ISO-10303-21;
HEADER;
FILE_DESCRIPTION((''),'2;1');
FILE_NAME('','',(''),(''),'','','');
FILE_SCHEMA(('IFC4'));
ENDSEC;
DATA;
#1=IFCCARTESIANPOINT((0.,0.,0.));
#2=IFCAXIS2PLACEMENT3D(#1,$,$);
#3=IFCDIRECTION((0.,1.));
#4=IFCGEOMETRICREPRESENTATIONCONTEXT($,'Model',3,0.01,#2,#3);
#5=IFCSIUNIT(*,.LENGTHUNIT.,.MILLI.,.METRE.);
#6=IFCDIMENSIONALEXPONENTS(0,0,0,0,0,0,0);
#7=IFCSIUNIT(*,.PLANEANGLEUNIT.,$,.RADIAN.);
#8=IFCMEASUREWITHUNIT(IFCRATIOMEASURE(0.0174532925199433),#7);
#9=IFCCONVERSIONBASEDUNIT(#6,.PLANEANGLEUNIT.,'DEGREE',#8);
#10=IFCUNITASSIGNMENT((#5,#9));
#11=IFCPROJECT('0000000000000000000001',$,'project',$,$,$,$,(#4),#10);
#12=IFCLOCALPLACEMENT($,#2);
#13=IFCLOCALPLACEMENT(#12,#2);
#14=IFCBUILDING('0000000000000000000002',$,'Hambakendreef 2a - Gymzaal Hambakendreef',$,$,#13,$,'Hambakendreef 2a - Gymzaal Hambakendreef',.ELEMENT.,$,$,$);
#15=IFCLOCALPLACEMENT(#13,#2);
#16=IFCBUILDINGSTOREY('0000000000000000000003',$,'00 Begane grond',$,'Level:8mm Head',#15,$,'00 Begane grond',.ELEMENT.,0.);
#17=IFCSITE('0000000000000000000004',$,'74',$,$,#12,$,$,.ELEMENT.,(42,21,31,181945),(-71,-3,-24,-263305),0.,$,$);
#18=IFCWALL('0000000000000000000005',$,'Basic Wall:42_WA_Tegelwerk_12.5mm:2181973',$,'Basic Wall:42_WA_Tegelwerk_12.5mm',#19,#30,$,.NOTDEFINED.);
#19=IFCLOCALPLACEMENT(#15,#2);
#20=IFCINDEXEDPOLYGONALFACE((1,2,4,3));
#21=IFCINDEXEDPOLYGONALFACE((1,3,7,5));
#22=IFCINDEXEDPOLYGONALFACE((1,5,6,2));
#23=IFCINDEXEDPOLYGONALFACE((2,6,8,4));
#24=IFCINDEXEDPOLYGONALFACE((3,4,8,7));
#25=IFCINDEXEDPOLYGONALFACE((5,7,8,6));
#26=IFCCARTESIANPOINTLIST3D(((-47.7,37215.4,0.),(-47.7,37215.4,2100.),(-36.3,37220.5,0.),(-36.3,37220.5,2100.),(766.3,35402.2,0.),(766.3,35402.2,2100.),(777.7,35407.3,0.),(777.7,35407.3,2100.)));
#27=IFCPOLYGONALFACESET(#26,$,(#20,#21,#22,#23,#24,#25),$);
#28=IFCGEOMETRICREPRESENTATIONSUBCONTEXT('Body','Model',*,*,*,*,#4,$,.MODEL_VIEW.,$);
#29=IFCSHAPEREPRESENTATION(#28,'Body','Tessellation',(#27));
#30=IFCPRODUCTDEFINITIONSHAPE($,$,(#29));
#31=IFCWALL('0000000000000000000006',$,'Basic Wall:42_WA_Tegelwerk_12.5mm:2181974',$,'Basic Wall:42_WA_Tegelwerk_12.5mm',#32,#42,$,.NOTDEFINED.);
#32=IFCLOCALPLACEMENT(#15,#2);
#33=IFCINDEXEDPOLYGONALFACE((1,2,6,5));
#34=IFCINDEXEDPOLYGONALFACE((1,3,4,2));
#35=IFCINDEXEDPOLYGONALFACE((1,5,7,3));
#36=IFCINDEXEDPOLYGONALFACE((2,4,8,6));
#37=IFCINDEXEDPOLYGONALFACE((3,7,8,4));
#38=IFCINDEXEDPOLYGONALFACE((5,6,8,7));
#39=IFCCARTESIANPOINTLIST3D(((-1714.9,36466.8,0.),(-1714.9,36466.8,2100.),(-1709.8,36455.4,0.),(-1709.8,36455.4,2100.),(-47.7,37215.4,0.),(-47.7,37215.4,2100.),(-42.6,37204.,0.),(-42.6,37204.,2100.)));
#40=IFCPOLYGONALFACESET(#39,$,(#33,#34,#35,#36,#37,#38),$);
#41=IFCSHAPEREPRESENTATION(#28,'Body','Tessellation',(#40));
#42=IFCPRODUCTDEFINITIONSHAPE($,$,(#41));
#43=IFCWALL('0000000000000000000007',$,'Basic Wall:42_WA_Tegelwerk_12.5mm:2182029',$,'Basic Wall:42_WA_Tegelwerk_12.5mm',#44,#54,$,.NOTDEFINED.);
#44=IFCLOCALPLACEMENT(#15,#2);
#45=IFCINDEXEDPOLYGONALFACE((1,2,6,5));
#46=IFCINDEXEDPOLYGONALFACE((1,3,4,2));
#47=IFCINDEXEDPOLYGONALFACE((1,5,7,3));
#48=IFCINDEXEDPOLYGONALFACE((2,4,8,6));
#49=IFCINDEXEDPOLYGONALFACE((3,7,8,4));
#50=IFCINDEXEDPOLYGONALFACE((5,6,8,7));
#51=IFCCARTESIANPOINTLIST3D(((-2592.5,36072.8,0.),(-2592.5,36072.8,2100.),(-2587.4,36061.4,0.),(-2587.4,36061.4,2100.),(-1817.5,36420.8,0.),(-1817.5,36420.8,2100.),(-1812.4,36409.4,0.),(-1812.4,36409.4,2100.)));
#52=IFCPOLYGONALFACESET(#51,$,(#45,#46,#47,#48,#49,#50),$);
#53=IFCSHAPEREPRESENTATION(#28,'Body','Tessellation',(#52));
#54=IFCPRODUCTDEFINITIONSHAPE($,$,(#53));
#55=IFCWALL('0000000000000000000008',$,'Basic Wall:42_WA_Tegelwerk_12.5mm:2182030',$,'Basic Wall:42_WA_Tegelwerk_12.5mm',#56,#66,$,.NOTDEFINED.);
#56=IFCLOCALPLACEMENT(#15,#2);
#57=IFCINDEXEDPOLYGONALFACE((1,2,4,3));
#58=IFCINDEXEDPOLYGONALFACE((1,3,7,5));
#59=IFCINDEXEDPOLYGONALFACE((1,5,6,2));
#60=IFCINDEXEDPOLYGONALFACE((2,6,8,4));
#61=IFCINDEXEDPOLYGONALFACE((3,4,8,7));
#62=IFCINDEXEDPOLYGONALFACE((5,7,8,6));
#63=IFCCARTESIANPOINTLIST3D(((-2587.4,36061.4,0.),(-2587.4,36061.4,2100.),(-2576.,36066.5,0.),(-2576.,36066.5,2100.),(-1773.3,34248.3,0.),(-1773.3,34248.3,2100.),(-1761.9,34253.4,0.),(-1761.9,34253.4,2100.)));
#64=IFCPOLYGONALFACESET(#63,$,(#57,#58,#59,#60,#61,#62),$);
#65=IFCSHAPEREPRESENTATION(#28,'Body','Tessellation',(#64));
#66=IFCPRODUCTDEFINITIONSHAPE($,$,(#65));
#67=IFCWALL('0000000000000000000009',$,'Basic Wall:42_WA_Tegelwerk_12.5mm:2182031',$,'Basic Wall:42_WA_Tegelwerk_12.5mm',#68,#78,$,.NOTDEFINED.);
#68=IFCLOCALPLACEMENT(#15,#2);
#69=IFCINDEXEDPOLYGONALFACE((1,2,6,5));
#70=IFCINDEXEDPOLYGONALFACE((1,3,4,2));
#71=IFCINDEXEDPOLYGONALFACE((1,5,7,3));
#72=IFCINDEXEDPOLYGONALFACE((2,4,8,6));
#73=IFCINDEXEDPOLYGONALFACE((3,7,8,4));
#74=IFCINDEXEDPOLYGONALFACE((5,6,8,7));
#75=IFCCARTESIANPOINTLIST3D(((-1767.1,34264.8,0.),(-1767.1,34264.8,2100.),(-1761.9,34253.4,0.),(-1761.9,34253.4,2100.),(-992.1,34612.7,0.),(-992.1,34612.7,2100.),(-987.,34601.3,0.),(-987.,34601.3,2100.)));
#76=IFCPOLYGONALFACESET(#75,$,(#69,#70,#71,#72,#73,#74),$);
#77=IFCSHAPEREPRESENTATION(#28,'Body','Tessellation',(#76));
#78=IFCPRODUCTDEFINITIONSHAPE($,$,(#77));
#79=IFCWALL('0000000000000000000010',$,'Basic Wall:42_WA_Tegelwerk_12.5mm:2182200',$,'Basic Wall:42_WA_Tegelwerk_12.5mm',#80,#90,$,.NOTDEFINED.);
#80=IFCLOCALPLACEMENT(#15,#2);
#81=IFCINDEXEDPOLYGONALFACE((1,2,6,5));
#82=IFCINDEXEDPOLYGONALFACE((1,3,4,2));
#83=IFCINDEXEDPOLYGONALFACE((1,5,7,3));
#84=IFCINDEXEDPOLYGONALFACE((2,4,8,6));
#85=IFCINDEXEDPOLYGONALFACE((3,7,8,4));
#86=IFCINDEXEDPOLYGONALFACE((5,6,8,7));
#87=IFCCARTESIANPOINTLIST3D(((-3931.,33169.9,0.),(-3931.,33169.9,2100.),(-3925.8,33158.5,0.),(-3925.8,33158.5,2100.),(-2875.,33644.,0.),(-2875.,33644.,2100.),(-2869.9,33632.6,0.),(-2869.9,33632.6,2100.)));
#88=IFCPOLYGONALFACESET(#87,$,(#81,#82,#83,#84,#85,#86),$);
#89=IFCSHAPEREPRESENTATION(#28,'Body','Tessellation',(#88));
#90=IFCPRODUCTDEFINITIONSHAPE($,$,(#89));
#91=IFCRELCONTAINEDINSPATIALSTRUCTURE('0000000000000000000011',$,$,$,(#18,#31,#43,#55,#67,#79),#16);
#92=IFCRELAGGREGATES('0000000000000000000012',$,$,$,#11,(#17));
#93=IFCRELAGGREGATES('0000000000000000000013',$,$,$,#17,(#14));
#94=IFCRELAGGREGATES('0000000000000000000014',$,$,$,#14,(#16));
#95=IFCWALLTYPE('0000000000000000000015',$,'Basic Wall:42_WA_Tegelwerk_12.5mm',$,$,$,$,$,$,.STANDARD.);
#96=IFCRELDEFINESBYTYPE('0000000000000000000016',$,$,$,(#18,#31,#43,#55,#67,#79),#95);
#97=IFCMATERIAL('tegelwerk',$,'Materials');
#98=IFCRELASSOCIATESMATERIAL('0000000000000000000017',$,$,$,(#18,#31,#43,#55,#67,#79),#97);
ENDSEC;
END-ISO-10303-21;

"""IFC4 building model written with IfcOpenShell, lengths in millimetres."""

from ifc_helpers import new_model, entity, si_unit, converted_unit, direction, frame, origin, place, context, subcontext, project, spatial, indexed_curve, outline, extrude, material, type_object, element, save


model = new_model("IFC4")

# Units and contexts
model_context = context("Model", 3, precision=0.01, world=origin(), true_north=direction((0.0, 1.0)))
body_context = subcontext(model_context, "Body", "Model", "MODEL_VIEW")
ifc_project = project(units=[si_unit("LENGTHUNIT", "METRE", prefix="MILLI"), converted_unit("PLANEANGLEUNIT", "DEGREE", entity("IfcRatioMeasure", 0.0174532925199433), si_unit("PLANEANGLEUNIT", "RADIAN"), dimensions=[0, 0, 0, 0, 0, 0, 0])], contexts=[model_context])

# Site, building, storey
site_placement = place(None, origin())
site = spatial("IfcSite", under=ifc_project, at=site_placement, Name="74", CompositionType="ELEMENT", RefLatitude=(42, 21, 31, 181945), RefLongitude=(-71, -3, -24, -263305), RefElevation=0.0)
building_placement = place(site_placement, origin())
building = spatial("IfcBuilding", under=site, at=building_placement, Name="Hambakendreef 2a - Gymzaal Hambakendreef", LongName="Hambakendreef 2a - Gymzaal Hambakendreef", CompositionType="ELEMENT")
storey_placement = place(building_placement, origin())
storey = spatial("IfcBuildingStorey", under=building, at=storey_placement, Name="00 Begane grond", ObjectType="Level:8mm Head", LongName="00 Begane grond", CompositionType="ELEMENT", Elevation=0.0)

# Walls
ifc_material_1 = material(Name="tegelwerk", Category="Materials")
wall_type_1 = type_object("IfcWallType", Name="Basic Wall:42_WA_Tegelwerk_12.5mm", PredefinedType="STANDARD")
wall_1_placement = place(storey_placement, frame((-42.0, 37217.9, 0.0), z_axis=(0.0, 0.0, 1.0), x_axis=(0.40959, -0.91227, 0.0)))
element("IfcWall", 1, at=wall_1_placement, inside=storey, type_object=wall_type_1, material=ifc_material_1, Name="Basic Wall:42_WA_Tegelwerk_12.5mm:2181973", ObjectType="Basic Wall:42_WA_Tegelwerk_12.5mm", PredefinedType="NOTDEFINED", context=body_context, shape_type="SweptSolid", body=[
    extrude(outline(indexed_curve([(1987.5, 6.2), (0.0, 6.2), (0.0, -6.2), (1987.5, -6.2), (1987.5, 6.2)], self_intersect=False)), origin(), (0.0, 0.0, 1.0), 2100.0),
])
wall_2_placement = place(storey_placement, frame((-1712.4, 36461.1, 0.0), z_axis=(0.0, 0.0, 1.0), x_axis=(0.91227, 0.40959, 0.0)))
element("IfcWall", 2, at=wall_2_placement, inside=storey, type_object=wall_type_1, material=ifc_material_1, Name="Basic Wall:42_WA_Tegelwerk_12.5mm:2181974", ObjectType="Basic Wall:42_WA_Tegelwerk_12.5mm", PredefinedType="NOTDEFINED", context=body_context, shape_type="SweptSolid", body=[
    extrude(outline(indexed_curve([(1827.5, 6.2), (0.0, 6.2), (0.0, -6.2), (1827.5, -6.3), (1827.5, 6.2)], self_intersect=False)), origin(), (0.0, 0.0, 1.0), 2100.0),
])
wall_3_placement = place(storey_placement, frame((-2590.0, 36067.1, 0.0), z_axis=(0.0, 0.0, 1.0), x_axis=(0.91227, 0.40959, 0.0)))
element("IfcWall", 3, at=wall_3_placement, inside=storey, type_object=wall_type_1, material=ifc_material_1, Name="Basic Wall:42_WA_Tegelwerk_12.5mm:2182029", ObjectType="Basic Wall:42_WA_Tegelwerk_12.5mm", PredefinedType="NOTDEFINED", context=body_context, shape_type="SweptSolid", body=[
    extrude(outline(indexed_curve([(849.5, 6.2), (0.0, 6.2), (0.0, -6.2), (849.5, -6.2), (849.5, 6.2)], self_intersect=False)), origin(), (0.0, 0.0, 1.0), 2100.0),
])
wall_4_placement = place(storey_placement, frame((-1767.6, 34250.8, 0.0), z_axis=(0.0, 0.0, 1.0), x_axis=(-0.40959, 0.91227, 0.0)))
element("IfcWall", 4, at=wall_4_placement, inside=storey, type_object=wall_type_1, material=ifc_material_1, Name="Basic Wall:42_WA_Tegelwerk_12.5mm:2182030", ObjectType="Basic Wall:42_WA_Tegelwerk_12.5mm", PredefinedType="NOTDEFINED", context=body_context, shape_type="SweptSolid", body=[
    extrude(outline(indexed_curve([(1987.5, 6.2), (0.0, 6.2), (0.0, -6.2), (1987.5, -6.2), (1987.5, 6.2)], self_intersect=False)), origin(), (0.0, 0.0, 1.0), 2100.0),
])
wall_5_placement = place(storey_placement, frame((-989.5, 34607.0, 0.0), z_axis=(0.0, 0.0, 1.0), x_axis=(-0.91227, -0.40959, 0.0)))
element("IfcWall", 5, at=wall_5_placement, inside=storey, type_object=wall_type_1, material=ifc_material_1, Name="Basic Wall:42_WA_Tegelwerk_12.5mm:2182031", ObjectType="Basic Wall:42_WA_Tegelwerk_12.5mm", PredefinedType="NOTDEFINED", context=body_context, shape_type="SweptSolid", body=[
    extrude(outline(indexed_curve([(849.5, 6.2), (0.0, 6.2), (0.0, -6.2), (849.5, -6.2), (849.5, 6.2)], self_intersect=False)), origin(), (0.0, 0.0, 1.0), 2100.0),
])
wall_6_placement = place(storey_placement, frame((-3928.4, 33164.2, 0.0), z_axis=(0.0, 0.0, 1.0), x_axis=(0.91227, 0.40959, 0.0)))
element("IfcWall", 6, at=wall_6_placement, inside=storey, type_object=wall_type_1, material=ifc_material_1, Name="Basic Wall:42_WA_Tegelwerk_12.5mm:2182200", ObjectType="Basic Wall:42_WA_Tegelwerk_12.5mm", PredefinedType="NOTDEFINED", context=body_context, shape_type="SweptSolid", body=[
    extrude(outline(indexed_curve([(1157.5, 6.3), (0.0, 6.2), (0.0, -6.2), (1157.5, -6.2), (1157.5, 6.3)], self_intersect=False)), origin(), (0.0, 0.0, 1.0), 2100.0),
])

save(model, "model.ifc")
